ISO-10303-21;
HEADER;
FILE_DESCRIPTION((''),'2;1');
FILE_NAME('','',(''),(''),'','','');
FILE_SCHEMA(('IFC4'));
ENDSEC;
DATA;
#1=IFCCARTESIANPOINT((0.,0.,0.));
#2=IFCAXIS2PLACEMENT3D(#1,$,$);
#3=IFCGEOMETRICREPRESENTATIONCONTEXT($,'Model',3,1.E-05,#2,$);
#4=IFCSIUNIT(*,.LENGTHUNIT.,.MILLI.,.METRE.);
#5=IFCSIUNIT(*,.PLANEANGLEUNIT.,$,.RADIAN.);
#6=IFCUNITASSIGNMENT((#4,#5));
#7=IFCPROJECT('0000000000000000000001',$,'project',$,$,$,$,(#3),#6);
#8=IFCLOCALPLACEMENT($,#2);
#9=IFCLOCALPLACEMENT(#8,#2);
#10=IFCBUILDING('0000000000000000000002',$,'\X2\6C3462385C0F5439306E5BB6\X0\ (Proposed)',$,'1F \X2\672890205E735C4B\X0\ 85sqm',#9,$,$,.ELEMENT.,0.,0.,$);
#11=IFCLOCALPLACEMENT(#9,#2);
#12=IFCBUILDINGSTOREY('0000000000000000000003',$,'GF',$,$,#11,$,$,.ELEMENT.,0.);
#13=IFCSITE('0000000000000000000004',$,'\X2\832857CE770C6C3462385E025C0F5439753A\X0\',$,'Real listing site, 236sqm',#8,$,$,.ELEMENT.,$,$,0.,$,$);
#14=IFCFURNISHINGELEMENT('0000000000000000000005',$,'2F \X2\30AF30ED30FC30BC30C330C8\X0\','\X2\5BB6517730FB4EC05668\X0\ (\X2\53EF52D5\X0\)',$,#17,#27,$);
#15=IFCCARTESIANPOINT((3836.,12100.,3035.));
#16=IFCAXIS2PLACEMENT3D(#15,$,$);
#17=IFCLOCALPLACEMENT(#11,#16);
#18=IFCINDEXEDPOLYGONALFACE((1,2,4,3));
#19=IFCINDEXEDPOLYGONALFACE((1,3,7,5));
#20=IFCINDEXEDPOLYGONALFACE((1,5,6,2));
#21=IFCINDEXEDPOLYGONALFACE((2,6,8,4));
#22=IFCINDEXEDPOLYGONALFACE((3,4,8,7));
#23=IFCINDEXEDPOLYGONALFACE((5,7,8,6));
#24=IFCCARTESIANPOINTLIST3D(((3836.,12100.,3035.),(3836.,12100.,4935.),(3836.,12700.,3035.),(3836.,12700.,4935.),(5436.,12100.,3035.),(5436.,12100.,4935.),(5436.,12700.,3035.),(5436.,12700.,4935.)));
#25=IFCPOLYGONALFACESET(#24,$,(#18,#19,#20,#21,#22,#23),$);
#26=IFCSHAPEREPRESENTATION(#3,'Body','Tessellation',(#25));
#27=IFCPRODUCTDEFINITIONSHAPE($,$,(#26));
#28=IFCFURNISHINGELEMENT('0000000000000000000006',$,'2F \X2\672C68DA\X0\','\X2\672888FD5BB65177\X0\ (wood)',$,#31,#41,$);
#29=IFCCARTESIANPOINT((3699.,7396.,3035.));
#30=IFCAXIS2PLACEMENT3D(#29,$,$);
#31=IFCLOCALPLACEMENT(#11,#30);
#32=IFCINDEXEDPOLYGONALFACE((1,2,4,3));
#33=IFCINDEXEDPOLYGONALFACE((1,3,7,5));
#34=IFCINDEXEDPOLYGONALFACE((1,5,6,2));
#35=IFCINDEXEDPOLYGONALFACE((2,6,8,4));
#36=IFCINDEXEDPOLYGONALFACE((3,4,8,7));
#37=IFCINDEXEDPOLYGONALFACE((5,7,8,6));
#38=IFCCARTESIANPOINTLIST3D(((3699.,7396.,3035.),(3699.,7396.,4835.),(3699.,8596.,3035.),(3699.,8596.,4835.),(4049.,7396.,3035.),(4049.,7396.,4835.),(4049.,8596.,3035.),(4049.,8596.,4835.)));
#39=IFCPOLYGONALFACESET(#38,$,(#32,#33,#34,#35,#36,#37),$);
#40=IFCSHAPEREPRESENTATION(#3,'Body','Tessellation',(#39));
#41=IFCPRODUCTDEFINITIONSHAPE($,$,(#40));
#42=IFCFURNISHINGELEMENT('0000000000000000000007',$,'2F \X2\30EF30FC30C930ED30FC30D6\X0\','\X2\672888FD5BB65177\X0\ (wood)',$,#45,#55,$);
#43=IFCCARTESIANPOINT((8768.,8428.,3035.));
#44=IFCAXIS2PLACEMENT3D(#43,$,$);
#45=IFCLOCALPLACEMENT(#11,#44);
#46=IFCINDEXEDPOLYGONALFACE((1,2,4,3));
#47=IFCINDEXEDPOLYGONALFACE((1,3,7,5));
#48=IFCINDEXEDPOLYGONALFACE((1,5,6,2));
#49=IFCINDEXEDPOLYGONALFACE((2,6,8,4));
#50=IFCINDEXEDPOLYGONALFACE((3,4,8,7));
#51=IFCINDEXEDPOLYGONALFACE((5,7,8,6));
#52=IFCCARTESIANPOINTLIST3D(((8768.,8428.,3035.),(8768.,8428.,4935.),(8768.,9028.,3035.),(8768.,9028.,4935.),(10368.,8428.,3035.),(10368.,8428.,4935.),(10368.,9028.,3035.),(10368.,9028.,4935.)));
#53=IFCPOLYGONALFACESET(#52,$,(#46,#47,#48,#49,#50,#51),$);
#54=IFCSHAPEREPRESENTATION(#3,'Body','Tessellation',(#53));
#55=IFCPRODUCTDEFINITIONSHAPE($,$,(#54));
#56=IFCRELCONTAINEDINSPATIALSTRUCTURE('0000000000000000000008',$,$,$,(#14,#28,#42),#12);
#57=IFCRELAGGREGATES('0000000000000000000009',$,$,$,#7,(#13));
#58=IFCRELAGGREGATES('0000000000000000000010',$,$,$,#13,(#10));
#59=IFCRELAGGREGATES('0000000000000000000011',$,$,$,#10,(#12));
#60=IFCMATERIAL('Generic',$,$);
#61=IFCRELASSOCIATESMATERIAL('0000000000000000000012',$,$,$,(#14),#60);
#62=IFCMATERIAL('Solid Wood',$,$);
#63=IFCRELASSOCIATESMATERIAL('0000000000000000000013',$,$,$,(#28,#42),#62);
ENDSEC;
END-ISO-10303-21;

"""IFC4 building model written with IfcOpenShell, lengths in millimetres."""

from ifc_helpers import new_model, si_unit, frame, frame_2d, origin, place, context, project, spatial, rectangle, extrude, material, element, save


model = new_model("IFC4")

# Units and contexts
model_context = context("Model", 3, precision=1e-05, world=origin())
ifc_project = project(units=[si_unit("LENGTHUNIT", "METRE", prefix="MILLI"), si_unit("PLANEANGLEUNIT", "RADIAN")], contexts=[model_context])

# Site, building, storey
site_placement = place(None, origin())
site = spatial("IfcSite", under=ifc_project, at=site_placement, Name="茨城県水戸市小吹町", ObjectType="Real listing site, 236sqm", CompositionType="ELEMENT", RefElevation=0.0)
building_placement = place(site_placement, origin())
building = spatial("IfcBuilding", under=site, at=building_placement, Name="水戸小吹の家 (Proposed)", ObjectType="1F 木造平屋 85sqm", CompositionType="ELEMENT", ElevationOfRefHeight=0.0, ElevationOfTerrain=0.0)
storey_placement = place(building_placement, origin())
storey = spatial("IfcBuildingStorey", under=building, at=storey_placement, Name="GF", CompositionType="ELEMENT", Elevation=0.0)

# Shared definitions
ifc_material_1 = material(Name="Solid Wood")

# Shared definitions
ifc_material_2 = material(Name="Generic")

# Furnishing elements
furnishing_1_placement = place(storey_placement, frame((3836.0, 12100.0, 3035.0)))
element("IfcFurnishingElement", 1, at=furnishing_1_placement, inside=storey, material=ifc_material_2, Name="2F クローゼット", Description="家具・什器 (可動)", context=model_context, shape_type="SweptSolid", body=[
    extrude(rectangle(XDim=1600.0, YDim=600.0, at=frame_2d((800.0, 300.0))), frame((3836.0, 12100.0, 3035.0)), (0.0, 0.0, 1.0), 1900.0),
])
furnishing_2_placement = place(storey_placement, frame((3699.0, 7396.0, 3035.0)))
element("IfcFurnishingElement", 2, at=furnishing_2_placement, inside=storey, material=ifc_material_1, Name="2F 本棚", Description="木製家具 (wood)", context=model_context, shape_type="SweptSolid", body=[
    extrude(rectangle(XDim=350.0, YDim=1200.0, at=frame_2d((175.0, 600.0))), frame((3699.0, 7396.0, 3035.0)), (0.0, 0.0, 1.0), 1800.0),
])
furnishing_3_placement = place(storey_placement, frame((8768.0, 8428.0, 3035.0)))
element("IfcFurnishingElement", 3, at=furnishing_3_placement, inside=storey, material=ifc_material_1, Name="2F ワードローブ", Description="木製家具 (wood)", context=model_context, shape_type="SweptSolid", body=[
    extrude(rectangle(XDim=1600.0, YDim=600.0, at=frame_2d((800.0, 300.0))), frame((8768.0, 8428.0, 3035.0)), (0.0, 0.0, 1.0), 1900.0),
])

save(model, "model.ifc")
